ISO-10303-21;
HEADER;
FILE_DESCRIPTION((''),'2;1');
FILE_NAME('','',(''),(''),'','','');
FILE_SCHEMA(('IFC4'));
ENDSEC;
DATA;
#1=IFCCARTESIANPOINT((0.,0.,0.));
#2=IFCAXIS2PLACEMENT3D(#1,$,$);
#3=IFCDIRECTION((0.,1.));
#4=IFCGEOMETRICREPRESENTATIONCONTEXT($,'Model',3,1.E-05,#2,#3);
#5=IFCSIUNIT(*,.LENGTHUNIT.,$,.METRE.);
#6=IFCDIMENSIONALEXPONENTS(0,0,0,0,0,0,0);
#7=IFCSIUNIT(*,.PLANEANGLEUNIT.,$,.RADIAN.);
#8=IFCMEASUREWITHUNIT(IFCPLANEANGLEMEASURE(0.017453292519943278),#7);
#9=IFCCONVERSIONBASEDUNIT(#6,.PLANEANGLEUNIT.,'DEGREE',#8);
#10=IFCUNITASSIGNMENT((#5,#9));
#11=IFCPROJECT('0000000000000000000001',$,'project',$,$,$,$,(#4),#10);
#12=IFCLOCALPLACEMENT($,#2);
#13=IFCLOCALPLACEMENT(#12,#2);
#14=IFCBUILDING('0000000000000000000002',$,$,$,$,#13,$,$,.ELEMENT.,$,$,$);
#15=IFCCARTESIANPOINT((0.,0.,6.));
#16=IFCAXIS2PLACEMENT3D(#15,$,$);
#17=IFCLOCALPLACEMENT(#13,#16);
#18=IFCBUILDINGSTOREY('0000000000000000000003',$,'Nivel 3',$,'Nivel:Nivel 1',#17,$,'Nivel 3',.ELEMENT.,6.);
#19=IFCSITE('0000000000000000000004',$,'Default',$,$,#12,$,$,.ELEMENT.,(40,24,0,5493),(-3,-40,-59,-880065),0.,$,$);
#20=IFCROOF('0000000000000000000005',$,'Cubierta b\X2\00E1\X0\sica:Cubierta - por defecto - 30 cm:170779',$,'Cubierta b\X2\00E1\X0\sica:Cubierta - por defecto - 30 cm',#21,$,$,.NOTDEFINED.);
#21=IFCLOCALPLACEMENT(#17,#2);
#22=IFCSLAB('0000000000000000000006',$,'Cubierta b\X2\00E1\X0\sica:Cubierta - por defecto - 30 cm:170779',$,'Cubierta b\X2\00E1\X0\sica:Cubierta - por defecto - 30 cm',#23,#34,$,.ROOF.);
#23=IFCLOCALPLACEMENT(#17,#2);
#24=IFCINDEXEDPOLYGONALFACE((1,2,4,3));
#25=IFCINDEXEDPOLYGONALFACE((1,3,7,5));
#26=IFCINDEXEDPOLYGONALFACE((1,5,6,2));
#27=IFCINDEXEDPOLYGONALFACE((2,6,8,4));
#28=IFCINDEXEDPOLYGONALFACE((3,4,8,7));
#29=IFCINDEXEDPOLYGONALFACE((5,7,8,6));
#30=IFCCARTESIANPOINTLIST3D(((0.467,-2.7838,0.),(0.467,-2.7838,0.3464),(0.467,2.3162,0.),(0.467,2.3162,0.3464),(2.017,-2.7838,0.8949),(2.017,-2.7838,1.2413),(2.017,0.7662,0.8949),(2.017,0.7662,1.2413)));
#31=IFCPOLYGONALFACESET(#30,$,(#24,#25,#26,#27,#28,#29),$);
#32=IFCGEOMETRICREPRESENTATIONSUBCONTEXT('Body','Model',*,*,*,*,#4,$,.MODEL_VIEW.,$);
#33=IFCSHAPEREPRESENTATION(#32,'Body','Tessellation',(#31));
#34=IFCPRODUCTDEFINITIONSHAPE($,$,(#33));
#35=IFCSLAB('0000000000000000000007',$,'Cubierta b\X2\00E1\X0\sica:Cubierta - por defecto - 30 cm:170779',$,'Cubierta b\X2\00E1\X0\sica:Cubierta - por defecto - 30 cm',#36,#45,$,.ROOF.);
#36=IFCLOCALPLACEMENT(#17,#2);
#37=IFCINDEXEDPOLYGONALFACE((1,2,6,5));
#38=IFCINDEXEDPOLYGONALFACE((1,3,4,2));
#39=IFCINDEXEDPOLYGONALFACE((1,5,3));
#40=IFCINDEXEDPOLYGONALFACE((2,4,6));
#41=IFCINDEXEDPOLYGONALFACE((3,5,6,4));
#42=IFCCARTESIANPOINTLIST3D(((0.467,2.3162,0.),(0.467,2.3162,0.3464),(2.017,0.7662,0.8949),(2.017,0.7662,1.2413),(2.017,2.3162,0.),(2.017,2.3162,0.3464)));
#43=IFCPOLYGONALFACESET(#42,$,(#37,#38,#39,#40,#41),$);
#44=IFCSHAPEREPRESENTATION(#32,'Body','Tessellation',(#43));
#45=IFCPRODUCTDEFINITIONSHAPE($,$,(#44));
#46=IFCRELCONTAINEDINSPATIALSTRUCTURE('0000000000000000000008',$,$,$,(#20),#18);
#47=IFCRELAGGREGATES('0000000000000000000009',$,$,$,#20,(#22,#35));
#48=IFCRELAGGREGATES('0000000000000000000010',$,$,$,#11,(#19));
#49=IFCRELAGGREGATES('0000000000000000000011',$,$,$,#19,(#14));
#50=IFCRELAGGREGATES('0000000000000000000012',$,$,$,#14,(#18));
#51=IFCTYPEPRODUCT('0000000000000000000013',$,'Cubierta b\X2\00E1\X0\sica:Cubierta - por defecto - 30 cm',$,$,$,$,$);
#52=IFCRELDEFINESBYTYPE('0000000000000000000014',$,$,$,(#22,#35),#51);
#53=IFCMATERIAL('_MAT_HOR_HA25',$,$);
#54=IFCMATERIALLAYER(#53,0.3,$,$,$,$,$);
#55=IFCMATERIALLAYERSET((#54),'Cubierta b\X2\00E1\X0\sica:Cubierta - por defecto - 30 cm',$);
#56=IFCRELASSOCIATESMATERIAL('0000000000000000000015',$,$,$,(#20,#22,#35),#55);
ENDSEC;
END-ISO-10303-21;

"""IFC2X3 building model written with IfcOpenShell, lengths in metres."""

from ifc_helpers import new_model, entity, si_unit, converted_unit, direction, frame, origin, place, context, subcontext, project, spatial, polyline, outline, extrude, material, layer, layer_set, type_object, element, aggregate, save


model = new_model("IFC2X3")

# Units and contexts
model_context = context("Model", 3, precision=1e-05, world=origin(), true_north=direction((0.0, 1.0)))
body_context = subcontext(model_context, "Body", "Model", "MODEL_VIEW")
ifc_project = project(units=[si_unit("LENGTHUNIT", "METRE"), converted_unit("PLANEANGLEUNIT", "DEGREE", entity("IfcPlaneAngleMeasure", 0.017453292519943278), si_unit("PLANEANGLEUNIT", "RADIAN"), dimensions=[0, 0, 0, 0, 0, 0, 0])], contexts=[model_context])

# Site, building, storey
site_placement = place(None, origin())
site = spatial("IfcSite", under=ifc_project, at=site_placement, Name="Default", CompositionType="ELEMENT", RefLatitude=(40, 24, 0, 5493), RefLongitude=(-3, -40, -59, -880065), RefElevation=0.0)
building_placement = place(site_placement, origin())
building = spatial("IfcBuilding", under=site, at=building_placement, CompositionType="ELEMENT")
storey_placement = place(building_placement, frame((0.0, 0.0, 6.0)))
storey = spatial("IfcBuildingStorey", under=building, at=storey_placement, Name="Nivel 3", ObjectType="Nivel:Nivel 1", LongName="Nivel 3", CompositionType="ELEMENT", Elevation=6.0)

# Roof, slabs
ifc_material = material(Name="_MAT_HOR_HA25")
ifc_layer = layer(ifc_material, 0.3)
ifc_layer_set = layer_set([ifc_layer], Name="Cubierta básica:Cubierta - por defecto - 30 cm")
roof_placement = place(storey_placement, frame((0.467, -2.7838, 0.0)))
roof = element("IfcRoof", 1, at=roof_placement, inside=storey, material=ifc_layer_set, Name="Cubierta básica:Cubierta - por defecto - 30 cm:170779", ObjectType="Cubierta básica:Cubierta - por defecto - 30 cm", ShapeType="NOTDEFINED")
type_product = type_object("IfcTypeProduct", Name="Cubierta básica:Cubierta - por defecto - 30 cm")
slab_1_placement = place(roof_placement, origin())
slab_1 = element("IfcSlab", 2, at=slab_1_placement, type_object=type_product, material=ifc_layer_set, Name="Cubierta básica:Cubierta - por defecto - 30 cm:170779", ObjectType="Cubierta básica:Cubierta - por defecto - 30 cm", PredefinedType="ROOF", context=body_context, shape_type="SweptSolid", body=[
    extrude(outline(polyline([(0.8949, 1.0), (-0.8949, 2.55), (-0.8949, -2.55), (0.8949, -2.55), (0.8949, 1.0)])), frame((0.775, 2.55, 0.4474), z_axis=(-0.5, 0.0, 0.866025), x_axis=(0.866025, 0.0, 0.5)), (0.5, 0.0, 0.866025), 0.3464),
])
slab_2_placement = place(roof_placement, origin())
slab_2 = element("IfcSlab", 3, at=slab_2_placement, type_object=type_product, material=ifc_layer_set, Name="Cubierta básica:Cubierta - por defecto - 30 cm:170779", ObjectType="Cubierta básica:Cubierta - por defecto - 30 cm", PredefinedType="ROOF", context=body_context, shape_type="SweptSolid", body=[
    extrude(outline(polyline([(-0.775, 0.8949), (0.775, -0.8949), (0.775, 0.8949), (-0.775, 0.8949)])), frame((0.775, 4.325, 0.4474), z_axis=(0.0, 0.5, 0.866025), x_axis=(1.0, 0.0, 0.0)), (0.0, -0.5, 0.866025), 0.3464),
])
aggregate(roof, [slab_1, slab_2])

save(model, "model.ifc")
